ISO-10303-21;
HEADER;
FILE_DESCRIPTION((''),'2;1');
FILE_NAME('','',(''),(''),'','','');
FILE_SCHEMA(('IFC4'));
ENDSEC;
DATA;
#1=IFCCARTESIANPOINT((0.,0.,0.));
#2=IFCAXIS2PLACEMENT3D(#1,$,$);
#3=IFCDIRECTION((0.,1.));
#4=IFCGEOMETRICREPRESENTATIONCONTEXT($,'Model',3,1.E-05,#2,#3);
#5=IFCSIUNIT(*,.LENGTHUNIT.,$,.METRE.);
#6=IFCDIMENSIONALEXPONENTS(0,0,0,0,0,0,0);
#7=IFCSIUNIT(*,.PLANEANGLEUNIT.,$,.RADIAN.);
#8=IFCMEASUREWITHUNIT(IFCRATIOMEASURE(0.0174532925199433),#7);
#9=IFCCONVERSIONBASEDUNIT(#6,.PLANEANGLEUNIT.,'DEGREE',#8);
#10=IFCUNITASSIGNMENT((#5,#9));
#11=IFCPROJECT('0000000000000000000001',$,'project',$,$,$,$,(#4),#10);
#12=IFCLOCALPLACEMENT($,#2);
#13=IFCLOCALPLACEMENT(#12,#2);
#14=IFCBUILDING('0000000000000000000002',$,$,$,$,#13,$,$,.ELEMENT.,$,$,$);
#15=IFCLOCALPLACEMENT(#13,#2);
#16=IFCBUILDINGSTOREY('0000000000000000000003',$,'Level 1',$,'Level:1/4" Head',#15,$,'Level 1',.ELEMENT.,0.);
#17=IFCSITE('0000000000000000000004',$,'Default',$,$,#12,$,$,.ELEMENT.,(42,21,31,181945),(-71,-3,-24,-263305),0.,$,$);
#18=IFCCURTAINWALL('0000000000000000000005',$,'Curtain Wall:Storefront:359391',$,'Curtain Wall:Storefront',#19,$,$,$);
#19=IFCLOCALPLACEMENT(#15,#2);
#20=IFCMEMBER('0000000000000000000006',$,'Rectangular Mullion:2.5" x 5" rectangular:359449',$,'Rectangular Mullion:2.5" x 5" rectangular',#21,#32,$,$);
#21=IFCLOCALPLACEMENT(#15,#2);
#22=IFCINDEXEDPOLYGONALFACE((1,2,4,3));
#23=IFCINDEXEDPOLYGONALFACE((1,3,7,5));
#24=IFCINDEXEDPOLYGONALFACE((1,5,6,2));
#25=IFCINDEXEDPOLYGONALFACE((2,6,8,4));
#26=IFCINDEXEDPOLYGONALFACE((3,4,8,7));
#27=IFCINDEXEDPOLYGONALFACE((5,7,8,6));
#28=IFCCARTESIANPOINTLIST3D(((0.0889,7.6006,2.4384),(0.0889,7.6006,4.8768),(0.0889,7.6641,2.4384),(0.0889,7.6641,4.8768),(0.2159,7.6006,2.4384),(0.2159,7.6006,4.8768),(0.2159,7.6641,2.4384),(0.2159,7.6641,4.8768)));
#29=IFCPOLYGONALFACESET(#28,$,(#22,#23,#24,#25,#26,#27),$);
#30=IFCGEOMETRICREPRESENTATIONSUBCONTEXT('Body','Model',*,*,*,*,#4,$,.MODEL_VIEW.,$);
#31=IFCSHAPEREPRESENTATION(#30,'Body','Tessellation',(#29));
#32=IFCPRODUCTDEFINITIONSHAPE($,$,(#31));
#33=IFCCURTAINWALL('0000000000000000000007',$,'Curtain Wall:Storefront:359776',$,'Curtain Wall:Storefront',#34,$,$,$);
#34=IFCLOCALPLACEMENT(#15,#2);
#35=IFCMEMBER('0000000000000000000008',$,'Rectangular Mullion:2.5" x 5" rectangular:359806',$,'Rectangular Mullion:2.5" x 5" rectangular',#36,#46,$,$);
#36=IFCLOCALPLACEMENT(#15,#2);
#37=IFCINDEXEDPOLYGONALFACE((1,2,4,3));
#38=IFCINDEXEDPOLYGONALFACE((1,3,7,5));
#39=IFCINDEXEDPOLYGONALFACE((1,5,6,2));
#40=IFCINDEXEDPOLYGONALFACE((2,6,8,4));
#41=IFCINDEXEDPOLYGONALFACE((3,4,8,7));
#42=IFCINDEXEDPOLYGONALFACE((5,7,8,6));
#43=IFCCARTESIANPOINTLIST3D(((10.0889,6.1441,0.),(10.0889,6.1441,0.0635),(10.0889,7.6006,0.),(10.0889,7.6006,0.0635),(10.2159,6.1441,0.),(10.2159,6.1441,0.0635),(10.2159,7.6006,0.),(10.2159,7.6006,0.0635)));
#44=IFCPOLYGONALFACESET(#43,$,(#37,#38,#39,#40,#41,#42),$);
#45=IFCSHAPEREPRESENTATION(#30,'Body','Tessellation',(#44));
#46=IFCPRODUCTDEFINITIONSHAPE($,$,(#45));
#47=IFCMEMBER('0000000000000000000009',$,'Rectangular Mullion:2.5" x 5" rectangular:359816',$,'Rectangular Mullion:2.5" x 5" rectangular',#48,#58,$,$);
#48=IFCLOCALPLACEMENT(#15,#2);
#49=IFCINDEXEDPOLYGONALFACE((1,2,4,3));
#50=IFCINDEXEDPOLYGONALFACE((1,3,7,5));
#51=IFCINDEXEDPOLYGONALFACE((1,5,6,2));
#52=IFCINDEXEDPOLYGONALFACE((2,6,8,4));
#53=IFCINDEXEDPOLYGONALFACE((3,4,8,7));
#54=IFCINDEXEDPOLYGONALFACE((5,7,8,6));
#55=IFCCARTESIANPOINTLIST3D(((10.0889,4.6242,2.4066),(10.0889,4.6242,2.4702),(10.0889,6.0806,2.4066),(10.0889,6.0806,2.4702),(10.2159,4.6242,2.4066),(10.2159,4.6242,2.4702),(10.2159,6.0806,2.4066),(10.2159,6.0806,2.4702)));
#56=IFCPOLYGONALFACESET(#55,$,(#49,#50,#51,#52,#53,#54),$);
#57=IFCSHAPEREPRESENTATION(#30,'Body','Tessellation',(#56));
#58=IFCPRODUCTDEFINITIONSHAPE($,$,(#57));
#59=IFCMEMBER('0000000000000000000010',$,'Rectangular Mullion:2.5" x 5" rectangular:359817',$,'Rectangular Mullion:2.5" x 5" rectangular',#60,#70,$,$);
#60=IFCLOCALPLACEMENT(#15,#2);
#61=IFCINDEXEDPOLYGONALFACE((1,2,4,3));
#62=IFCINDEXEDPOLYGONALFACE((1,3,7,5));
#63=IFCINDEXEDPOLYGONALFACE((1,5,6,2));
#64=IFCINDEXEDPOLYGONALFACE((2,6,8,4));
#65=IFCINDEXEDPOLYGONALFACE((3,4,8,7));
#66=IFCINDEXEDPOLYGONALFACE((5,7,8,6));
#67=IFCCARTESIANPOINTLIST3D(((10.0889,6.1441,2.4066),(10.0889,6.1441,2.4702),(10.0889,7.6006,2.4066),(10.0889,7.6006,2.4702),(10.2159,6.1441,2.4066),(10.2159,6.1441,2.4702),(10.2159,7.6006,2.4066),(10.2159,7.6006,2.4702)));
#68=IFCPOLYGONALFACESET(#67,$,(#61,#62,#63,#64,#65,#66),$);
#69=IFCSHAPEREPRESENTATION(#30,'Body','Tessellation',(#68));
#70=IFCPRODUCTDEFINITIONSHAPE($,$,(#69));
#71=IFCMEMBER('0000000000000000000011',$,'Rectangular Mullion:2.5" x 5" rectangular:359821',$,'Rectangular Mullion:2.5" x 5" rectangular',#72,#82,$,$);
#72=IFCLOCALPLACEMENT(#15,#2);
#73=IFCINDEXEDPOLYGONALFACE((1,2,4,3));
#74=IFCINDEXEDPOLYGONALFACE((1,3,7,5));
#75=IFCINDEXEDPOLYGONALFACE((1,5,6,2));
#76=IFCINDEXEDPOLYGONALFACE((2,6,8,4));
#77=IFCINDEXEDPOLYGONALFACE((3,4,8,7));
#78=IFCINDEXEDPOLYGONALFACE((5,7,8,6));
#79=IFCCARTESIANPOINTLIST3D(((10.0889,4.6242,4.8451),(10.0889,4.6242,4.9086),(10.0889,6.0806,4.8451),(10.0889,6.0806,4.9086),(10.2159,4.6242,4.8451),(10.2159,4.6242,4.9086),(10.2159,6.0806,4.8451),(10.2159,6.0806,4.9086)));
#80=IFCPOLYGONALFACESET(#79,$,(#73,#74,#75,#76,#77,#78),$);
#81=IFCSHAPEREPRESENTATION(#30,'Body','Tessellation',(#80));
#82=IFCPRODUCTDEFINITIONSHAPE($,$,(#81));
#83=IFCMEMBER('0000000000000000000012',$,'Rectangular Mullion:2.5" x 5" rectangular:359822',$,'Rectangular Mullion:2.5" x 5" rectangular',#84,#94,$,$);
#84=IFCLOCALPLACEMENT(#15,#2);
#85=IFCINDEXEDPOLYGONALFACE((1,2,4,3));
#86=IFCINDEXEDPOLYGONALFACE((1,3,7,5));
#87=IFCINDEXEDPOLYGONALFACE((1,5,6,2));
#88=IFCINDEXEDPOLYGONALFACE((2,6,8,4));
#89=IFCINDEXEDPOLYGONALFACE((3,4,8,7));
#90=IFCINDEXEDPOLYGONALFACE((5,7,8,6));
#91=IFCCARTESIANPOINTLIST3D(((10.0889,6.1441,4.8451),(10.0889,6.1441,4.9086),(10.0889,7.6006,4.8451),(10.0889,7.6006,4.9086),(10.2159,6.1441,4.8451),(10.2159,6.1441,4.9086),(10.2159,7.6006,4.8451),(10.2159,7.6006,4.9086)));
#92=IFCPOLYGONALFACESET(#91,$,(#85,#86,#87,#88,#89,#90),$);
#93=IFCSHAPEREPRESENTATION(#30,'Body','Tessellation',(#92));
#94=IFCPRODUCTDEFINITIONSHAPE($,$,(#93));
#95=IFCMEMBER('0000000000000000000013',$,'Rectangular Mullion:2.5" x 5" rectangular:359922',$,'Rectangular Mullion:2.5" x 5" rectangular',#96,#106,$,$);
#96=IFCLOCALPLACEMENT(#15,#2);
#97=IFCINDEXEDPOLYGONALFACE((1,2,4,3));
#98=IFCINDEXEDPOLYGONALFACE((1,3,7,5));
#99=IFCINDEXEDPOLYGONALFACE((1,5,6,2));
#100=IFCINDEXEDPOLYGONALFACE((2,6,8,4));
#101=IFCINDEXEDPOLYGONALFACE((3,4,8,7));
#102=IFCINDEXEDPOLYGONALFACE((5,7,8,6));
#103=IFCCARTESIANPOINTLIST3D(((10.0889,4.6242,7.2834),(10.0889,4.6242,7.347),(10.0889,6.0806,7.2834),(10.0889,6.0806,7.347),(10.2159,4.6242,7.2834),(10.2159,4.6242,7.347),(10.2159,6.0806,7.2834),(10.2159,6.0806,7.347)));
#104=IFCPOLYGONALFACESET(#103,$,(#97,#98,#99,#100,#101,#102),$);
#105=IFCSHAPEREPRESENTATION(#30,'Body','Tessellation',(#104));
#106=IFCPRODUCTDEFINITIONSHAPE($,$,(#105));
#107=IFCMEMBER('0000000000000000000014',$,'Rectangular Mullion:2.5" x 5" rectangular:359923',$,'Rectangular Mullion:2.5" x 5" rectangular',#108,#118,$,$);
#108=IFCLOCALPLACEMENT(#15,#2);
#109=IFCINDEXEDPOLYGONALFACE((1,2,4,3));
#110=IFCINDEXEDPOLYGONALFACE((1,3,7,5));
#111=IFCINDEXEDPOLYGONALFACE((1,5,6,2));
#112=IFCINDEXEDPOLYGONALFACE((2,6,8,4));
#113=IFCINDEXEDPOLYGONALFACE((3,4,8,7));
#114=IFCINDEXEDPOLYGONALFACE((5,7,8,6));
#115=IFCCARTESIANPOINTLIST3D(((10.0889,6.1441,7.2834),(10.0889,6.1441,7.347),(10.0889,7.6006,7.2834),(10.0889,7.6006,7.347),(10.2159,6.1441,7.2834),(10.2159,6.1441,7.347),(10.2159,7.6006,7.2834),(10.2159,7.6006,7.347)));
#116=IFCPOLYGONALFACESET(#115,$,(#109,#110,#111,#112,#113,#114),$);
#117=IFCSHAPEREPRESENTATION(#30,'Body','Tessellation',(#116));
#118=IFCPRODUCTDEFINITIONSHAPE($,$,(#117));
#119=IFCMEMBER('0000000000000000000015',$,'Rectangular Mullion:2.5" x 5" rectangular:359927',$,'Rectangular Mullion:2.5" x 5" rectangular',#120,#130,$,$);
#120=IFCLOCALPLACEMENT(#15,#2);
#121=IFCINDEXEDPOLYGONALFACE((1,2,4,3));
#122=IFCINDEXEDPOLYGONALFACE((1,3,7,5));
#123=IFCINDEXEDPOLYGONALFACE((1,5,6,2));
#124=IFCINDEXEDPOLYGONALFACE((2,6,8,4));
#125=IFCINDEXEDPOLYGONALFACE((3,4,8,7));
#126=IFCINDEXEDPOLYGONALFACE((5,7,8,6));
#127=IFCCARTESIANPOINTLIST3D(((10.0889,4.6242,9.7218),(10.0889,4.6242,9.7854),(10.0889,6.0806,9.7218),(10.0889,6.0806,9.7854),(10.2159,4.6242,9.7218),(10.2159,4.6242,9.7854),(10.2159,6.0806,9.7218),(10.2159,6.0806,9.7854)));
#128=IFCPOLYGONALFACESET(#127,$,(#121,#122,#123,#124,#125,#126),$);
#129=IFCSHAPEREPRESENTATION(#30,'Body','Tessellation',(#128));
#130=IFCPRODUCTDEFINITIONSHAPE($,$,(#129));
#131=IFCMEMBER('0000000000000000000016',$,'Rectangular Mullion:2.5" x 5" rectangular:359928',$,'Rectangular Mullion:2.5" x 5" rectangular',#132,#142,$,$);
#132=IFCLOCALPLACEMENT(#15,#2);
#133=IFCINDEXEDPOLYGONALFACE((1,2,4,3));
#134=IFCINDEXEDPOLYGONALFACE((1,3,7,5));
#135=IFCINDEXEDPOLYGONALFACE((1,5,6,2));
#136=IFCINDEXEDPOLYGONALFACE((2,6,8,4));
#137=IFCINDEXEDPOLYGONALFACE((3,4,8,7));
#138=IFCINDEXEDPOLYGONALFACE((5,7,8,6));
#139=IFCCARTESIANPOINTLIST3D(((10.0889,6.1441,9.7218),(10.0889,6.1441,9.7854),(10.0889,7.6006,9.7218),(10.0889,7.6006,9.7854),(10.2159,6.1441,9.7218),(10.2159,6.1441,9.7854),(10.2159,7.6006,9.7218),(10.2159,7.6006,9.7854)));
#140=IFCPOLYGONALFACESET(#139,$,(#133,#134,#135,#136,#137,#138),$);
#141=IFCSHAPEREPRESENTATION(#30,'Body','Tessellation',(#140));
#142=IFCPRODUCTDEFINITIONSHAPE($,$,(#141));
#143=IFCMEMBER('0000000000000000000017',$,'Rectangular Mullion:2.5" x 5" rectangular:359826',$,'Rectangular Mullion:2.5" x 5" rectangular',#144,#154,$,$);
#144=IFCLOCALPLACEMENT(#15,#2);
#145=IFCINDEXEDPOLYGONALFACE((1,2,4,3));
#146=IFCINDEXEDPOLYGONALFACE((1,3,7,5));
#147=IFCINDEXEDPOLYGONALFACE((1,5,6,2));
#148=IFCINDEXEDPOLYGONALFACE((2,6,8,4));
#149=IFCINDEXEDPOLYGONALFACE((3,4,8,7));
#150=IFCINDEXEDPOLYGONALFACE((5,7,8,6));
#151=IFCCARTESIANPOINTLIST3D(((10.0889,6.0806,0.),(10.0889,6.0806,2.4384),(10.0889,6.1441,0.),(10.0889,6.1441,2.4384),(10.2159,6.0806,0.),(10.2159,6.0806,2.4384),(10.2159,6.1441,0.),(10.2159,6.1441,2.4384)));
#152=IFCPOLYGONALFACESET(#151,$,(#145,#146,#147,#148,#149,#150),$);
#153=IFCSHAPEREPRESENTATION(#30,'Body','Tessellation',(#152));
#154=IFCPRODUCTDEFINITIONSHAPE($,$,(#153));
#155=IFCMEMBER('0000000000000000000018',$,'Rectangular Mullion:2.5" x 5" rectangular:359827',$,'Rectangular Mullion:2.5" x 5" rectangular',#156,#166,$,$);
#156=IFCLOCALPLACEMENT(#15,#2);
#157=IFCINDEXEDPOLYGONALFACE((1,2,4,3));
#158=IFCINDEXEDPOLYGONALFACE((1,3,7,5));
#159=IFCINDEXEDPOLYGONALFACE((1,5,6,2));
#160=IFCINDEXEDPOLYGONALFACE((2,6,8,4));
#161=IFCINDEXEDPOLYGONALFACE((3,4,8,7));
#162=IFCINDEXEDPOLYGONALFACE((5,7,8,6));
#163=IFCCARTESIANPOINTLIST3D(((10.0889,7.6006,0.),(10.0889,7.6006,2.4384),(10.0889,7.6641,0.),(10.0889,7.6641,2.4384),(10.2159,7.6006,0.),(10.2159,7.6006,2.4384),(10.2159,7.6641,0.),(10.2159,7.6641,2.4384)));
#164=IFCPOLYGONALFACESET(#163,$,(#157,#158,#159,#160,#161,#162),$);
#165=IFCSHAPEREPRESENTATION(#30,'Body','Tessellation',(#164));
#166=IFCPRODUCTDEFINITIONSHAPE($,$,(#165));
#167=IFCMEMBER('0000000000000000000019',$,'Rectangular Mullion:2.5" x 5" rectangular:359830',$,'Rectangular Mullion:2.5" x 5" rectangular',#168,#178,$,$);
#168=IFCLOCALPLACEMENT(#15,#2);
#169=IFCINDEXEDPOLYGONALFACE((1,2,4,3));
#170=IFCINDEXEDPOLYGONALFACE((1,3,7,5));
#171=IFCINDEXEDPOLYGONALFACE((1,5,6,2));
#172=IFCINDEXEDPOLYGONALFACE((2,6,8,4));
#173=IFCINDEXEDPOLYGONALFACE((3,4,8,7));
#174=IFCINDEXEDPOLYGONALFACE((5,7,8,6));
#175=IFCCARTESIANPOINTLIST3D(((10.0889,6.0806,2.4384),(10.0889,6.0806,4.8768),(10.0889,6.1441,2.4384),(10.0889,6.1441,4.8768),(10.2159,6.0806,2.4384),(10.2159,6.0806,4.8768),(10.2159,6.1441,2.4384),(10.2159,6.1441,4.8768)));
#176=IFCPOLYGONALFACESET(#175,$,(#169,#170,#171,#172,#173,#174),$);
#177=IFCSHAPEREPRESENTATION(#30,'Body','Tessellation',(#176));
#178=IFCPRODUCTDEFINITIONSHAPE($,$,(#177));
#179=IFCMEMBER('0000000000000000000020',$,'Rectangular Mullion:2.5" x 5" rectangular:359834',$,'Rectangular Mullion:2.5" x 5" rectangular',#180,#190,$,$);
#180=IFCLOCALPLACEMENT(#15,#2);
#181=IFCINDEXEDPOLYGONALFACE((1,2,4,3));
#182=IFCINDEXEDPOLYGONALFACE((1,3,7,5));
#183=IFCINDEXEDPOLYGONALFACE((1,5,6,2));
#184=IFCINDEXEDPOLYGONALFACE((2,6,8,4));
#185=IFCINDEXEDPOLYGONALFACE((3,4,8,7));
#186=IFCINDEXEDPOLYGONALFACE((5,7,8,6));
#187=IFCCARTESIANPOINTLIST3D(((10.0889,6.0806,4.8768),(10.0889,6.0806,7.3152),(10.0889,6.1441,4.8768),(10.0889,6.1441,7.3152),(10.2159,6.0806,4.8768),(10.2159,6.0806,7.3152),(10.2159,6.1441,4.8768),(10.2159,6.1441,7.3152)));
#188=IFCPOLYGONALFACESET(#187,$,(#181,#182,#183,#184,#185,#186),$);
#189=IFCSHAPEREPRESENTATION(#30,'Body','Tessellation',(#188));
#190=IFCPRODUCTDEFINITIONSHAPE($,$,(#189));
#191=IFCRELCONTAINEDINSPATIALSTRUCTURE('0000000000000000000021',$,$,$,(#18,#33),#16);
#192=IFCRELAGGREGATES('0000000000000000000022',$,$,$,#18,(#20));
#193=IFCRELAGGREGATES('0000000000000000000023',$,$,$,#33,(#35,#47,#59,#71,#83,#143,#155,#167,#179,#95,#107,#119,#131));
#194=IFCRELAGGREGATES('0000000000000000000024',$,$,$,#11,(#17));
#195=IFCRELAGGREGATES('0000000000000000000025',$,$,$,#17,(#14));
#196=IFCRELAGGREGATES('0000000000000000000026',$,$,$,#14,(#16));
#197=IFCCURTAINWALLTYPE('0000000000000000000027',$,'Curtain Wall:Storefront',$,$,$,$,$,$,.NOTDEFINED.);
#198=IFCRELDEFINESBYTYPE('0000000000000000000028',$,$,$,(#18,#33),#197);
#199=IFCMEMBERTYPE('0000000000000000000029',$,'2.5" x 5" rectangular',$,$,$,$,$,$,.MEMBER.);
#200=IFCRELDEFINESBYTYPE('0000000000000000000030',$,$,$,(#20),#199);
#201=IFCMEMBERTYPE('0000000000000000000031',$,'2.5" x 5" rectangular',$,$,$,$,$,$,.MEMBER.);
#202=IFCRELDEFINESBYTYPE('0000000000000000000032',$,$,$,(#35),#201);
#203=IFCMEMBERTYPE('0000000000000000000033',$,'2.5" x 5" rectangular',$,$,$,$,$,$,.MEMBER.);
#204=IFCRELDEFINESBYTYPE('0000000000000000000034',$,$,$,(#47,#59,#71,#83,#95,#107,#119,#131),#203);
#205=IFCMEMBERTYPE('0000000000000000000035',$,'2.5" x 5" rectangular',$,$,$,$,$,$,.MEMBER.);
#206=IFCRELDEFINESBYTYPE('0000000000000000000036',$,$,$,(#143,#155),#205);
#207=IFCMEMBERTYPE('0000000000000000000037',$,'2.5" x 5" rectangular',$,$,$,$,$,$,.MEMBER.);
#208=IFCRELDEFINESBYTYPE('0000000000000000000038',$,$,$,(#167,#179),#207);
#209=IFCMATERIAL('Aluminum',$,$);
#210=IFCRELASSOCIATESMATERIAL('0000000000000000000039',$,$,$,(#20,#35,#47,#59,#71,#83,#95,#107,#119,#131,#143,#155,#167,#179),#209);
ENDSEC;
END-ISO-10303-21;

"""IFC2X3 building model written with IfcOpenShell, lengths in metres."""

from ifc_helpers import new_model, entity, si_unit, converted_unit, direction, frame, origin, origin_2d_with_axis, place, context, subcontext, project, spatial, rectangle, extrude, source, transform, mapped, material, type_object, type_shapes, element, aggregate, save


model = new_model("IFC2X3")

# Units and contexts
model_context = context("Model", 3, precision=1e-05, world=origin(), true_north=direction((0.0, 1.0)))
body_context = subcontext(model_context, "Body", "Model", "MODEL_VIEW")
ifc_project = project(units=[si_unit("LENGTHUNIT", "METRE"), converted_unit("PLANEANGLEUNIT", "DEGREE", entity("IfcRatioMeasure", 0.0174532925199433), si_unit("PLANEANGLEUNIT", "RADIAN"), dimensions=[0, 0, 0, 0, 0, 0, 0])], contexts=[model_context])

# Site, building, storey
site_placement = place(None, origin())
site = spatial("IfcSite", under=ifc_project, at=site_placement, Name="Default", CompositionType="ELEMENT", RefLatitude=(42, 21, 31, 181945), RefLongitude=(-71, -3, -24, -263305), RefElevation=0.0)
building_placement = place(site_placement, origin())
building = spatial("IfcBuilding", under=site, at=building_placement, CompositionType="ELEMENT")
storey_placement = place(building_placement, origin())
storey = spatial("IfcBuildingStorey", under=building, at=storey_placement, Name="Level 1", ObjectType="Level:1/4\" Head", LongName="Level 1", CompositionType="ELEMENT", Elevation=0.0)

# Curtain wall, member
curtain_wall_type = type_object("IfcCurtainWallType", Name="Curtain Wall:Storefront", PredefinedType="NOTDEFINED")
curtain_wall_1_placement = place(storey_placement, origin())
curtain_wall_1 = element("IfcCurtainWall", 1, at=curtain_wall_1_placement, inside=storey, type_object=curtain_wall_type, Name="Curtain Wall:Storefront:359391", ObjectType="Curtain Wall:Storefront")
ifc_material_1 = material(Name="Aluminum")
member_type_1 = type_object("IfcMemberType", Name="2.5\" x 5\" rectangular", PredefinedType="MEMBER")
shared_shape_1 = source(origin(), body_context, "Body", "SweptSolid", [
    extrude(rectangle(XDim=0.127, YDim=0.0635, at=origin_2d_with_axis()), frame((0.0, 0.0, -2.4384), z_axis=(0.0, 0.0, 1.0), x_axis=(0.0, -1.0, 0.0)), (0.0, 0.0, 1.0), 2.4384),
])
type_shapes(member_type_1, [shared_shape_1])
member_1_placement = place(storey_placement, frame((0.1524, 7.6324, 2.4384), z_axis=(0.0, 0.0, -1.0), x_axis=(0.0, 1.0, 0.0)))
member_1 = element("IfcMember", 2, at=member_1_placement, type_object=member_type_1, material=ifc_material_1, Name="Rectangular Mullion:2.5\" x 5\" rectangular:359449", ObjectType="Rectangular Mullion:2.5\" x 5\" rectangular", context=body_context, shape_type="MappedRepresentation", body=[
    mapped(shared_shape_1, transform((0.0, 0.0, 0.0), scale=1.0)),
])
aggregate(curtain_wall_1, [member_1])

# Curtain wall, members
curtain_wall_2_placement = place(storey_placement, origin())
curtain_wall_2 = element("IfcCurtainWall", 3, at=curtain_wall_2_placement, inside=storey, type_object=curtain_wall_type, Name="Curtain Wall:Storefront:359776", ObjectType="Curtain Wall:Storefront")
member_type_2 = type_object("IfcMemberType", Name="2.5\" x 5\" rectangular", PredefinedType="MEMBER")
shared_shape_2 = source(origin(), body_context, "Body", "SweptSolid", [
    extrude(rectangle(XDim=0.127, YDim=0.0635, at=origin_2d_with_axis()), frame((-0.0318, 0.0, -1.4565), z_axis=(0.0, 0.0, 1.0), x_axis=(0.0, -1.0, 0.0)), (0.0, 0.0, 1.0), 1.4565),
])
type_shapes(member_type_2, [shared_shape_2])
member_2_placement = place(storey_placement, frame((10.1524, 6.1441, 0.0), z_axis=(0.0, -1.0, 0.0), x_axis=(0.0, 0.0, -1.0)))
member_2 = element("IfcMember", 4, at=member_2_placement, type_object=member_type_2, material=ifc_material_1, Name="Rectangular Mullion:2.5\" x 5\" rectangular:359806", ObjectType="Rectangular Mullion:2.5\" x 5\" rectangular", context=body_context, shape_type="MappedRepresentation", body=[
    mapped(shared_shape_2, transform((0.0, 0.0, 0.0), scale=1.0)),
])
member_type_3 = type_object("IfcMemberType", Name="2.5\" x 5\" rectangular", PredefinedType="MEMBER")
shared_shape_3 = source(origin(), body_context, "Body", "SweptSolid", [
    extrude(rectangle(XDim=0.127, YDim=0.0635, at=origin_2d_with_axis()), frame((0.0, 0.0, -1.4565), z_axis=(0.0, 0.0, 1.0), x_axis=(0.0, -1.0, 0.0)), (0.0, 0.0, 1.0), 1.4565),
])
type_shapes(member_type_3, [shared_shape_3])
member_3_placement = place(storey_placement, frame((10.1524, 6.0806, 2.4384), z_axis=(0.0, 1.0, 0.0), x_axis=(0.0, 0.0, 1.0)))
member_3 = element("IfcMember", 5, at=member_3_placement, type_object=member_type_3, material=ifc_material_1, Name="Rectangular Mullion:2.5\" x 5\" rectangular:359816", ObjectType="Rectangular Mullion:2.5\" x 5\" rectangular", context=body_context, shape_type="MappedRepresentation", body=[
    mapped(shared_shape_3, transform((0.0, 0.0, 0.0), scale=1.0)),
])
member_4_placement = place(storey_placement, frame((10.1524, 7.6006, 2.4384), z_axis=(0.0, 1.0, 0.0), x_axis=(0.0, 0.0, 1.0)))
member_4 = element("IfcMember", 6, at=member_4_placement, type_object=member_type_3, material=ifc_material_1, Name="Rectangular Mullion:2.5\" x 5\" rectangular:359817", ObjectType="Rectangular Mullion:2.5\" x 5\" rectangular", context=body_context, shape_type="MappedRepresentation", body=[
    mapped(shared_shape_3, transform((0.0, 0.0, 0.0), scale=1.0)),
])
member_5_placement = place(storey_placement, frame((10.1524, 6.0806, 4.8768), z_axis=(0.0, 1.0, 0.0), x_axis=(0.0, 0.0, 1.0)))
member_5 = element("IfcMember", 7, at=member_5_placement, type_object=member_type_3, material=ifc_material_1, Name="Rectangular Mullion:2.5\" x 5\" rectangular:359821", ObjectType="Rectangular Mullion:2.5\" x 5\" rectangular", context=body_context, shape_type="MappedRepresentation", body=[
    mapped(shared_shape_3, transform((0.0, 0.0, 0.0), scale=1.0)),
])
member_6_placement = place(storey_placement, frame((10.1524, 7.6006, 4.8768), z_axis=(0.0, 1.0, 0.0), x_axis=(0.0, 0.0, 1.0)))
member_6 = element("IfcMember", 8, at=member_6_placement, type_object=member_type_3, material=ifc_material_1, Name="Rectangular Mullion:2.5\" x 5\" rectangular:359822", ObjectType="Rectangular Mullion:2.5\" x 5\" rectangular", context=body_context, shape_type="MappedRepresentation", body=[
    mapped(shared_shape_3, transform((0.0, 0.0, 0.0), scale=1.0)),
])
member_7_placement = place(storey_placement, frame((10.1524, 6.0806, 7.3152), z_axis=(0.0, 1.0, 0.0), x_axis=(0.0, 0.0, 1.0)))
member_7 = element("IfcMember", 9, at=member_7_placement, type_object=member_type_3, material=ifc_material_1, Name="Rectangular Mullion:2.5\" x 5\" rectangular:359922", ObjectType="Rectangular Mullion:2.5\" x 5\" rectangular", context=body_context, shape_type="MappedRepresentation", body=[
    mapped(shared_shape_3, transform((0.0, 0.0, 0.0), scale=1.0)),
])
member_8_placement = place(storey_placement, frame((10.1524, 7.6006, 7.3152), z_axis=(0.0, 1.0, 0.0), x_axis=(0.0, 0.0, 1.0)))
member_8 = element("IfcMember", 10, at=member_8_placement, type_object=member_type_3, material=ifc_material_1, Name="Rectangular Mullion:2.5\" x 5\" rectangular:359923", ObjectType="Rectangular Mullion:2.5\" x 5\" rectangular", context=body_context, shape_type="MappedRepresentation", body=[
    mapped(shared_shape_3, transform((0.0, 0.0, 0.0), scale=1.0)),
])
member_9_placement = place(storey_placement, frame((10.1524, 6.0806, 9.7536), z_axis=(0.0, 1.0, 0.0), x_axis=(0.0, 0.0, 1.0)))
member_9 = element("IfcMember", 11, at=member_9_placement, type_object=member_type_3, material=ifc_material_1, Name="Rectangular Mullion:2.5\" x 5\" rectangular:359927", ObjectType="Rectangular Mullion:2.5\" x 5\" rectangular", context=body_context, shape_type="MappedRepresentation", body=[
    mapped(shared_shape_3, transform((0.0, 0.0, 0.0), scale=1.0)),
])
member_10_placement = place(storey_placement, frame((10.1524, 7.6006, 9.7536), z_axis=(0.0, 1.0, 0.0), x_axis=(0.0, 0.0, 1.0)))
member_10 = element("IfcMember", 12, at=member_10_placement, type_object=member_type_3, material=ifc_material_1, Name="Rectangular Mullion:2.5\" x 5\" rectangular:359928", ObjectType="Rectangular Mullion:2.5\" x 5\" rectangular", context=body_context, shape_type="MappedRepresentation", body=[
    mapped(shared_shape_3, transform((0.0, 0.0, 0.0), scale=1.0)),
])
member_type_4 = type_object("IfcMemberType", Name="2.5\" x 5\" rectangular", PredefinedType="MEMBER")
shared_shape_4 = source(origin(), body_context, "Body", "SweptSolid", [
    extrude(rectangle(XDim=0.127, YDim=0.0635, at=origin_2d_with_axis()), frame((0.0, 0.0, -2.4384), z_axis=(0.0, 0.0, 1.0), x_axis=(0.0, -1.0, 0.0)), (0.0, 0.0, 1.0), 2.4384),
])
type_shapes(member_type_4, [shared_shape_4])
member_11_placement = place(storey_placement, frame((10.1524, 6.1124, 0.0), z_axis=(0.0, 0.0, -1.0), x_axis=(0.0, 1.0, 0.0)))
member_11 = element("IfcMember", 13, at=member_11_placement, type_object=member_type_4, material=ifc_material_1, Name="Rectangular Mullion:2.5\" x 5\" rectangular:359826", ObjectType="Rectangular Mullion:2.5\" x 5\" rectangular", context=body_context, shape_type="MappedRepresentation", body=[
    mapped(shared_shape_4, transform((0.0, 0.0, 0.0), scale=1.0)),
])
member_12_placement = place(storey_placement, frame((10.1524, 7.6324, 0.0), z_axis=(0.0, 0.0, -1.0), x_axis=(0.0, 1.0, 0.0)))
member_12 = element("IfcMember", 14, at=member_12_placement, type_object=member_type_4, material=ifc_material_1, Name="Rectangular Mullion:2.5\" x 5\" rectangular:359827", ObjectType="Rectangular Mullion:2.5\" x 5\" rectangular", context=body_context, shape_type="MappedRepresentation", body=[
    mapped(shared_shape_4, transform((0.0, 0.0, 0.0), scale=1.0)),
])
member_type_5 = type_object("IfcMemberType", Name="2.5\" x 5\" rectangular", PredefinedType="MEMBER")
shared_shape_5 = source(origin(), body_context, "Body", "SweptSolid", [
    extrude(rectangle(XDim=0.127, YDim=0.0635, at=origin_2d_with_axis()), frame((0.0, 0.0, -2.4384), z_axis=(0.0, 0.0, 1.0), x_axis=(0.0, -1.0, 0.0)), (0.0, 0.0, 1.0), 2.4384),
])
type_shapes(member_type_5, [shared_shape_5])
member_13_placement = place(storey_placement, frame((10.1524, 6.1124, 2.4384), z_axis=(0.0, 0.0, -1.0), x_axis=(0.0, 1.0, 0.0)))
member_13 = element("IfcMember", 15, at=member_13_placement, type_object=member_type_5, material=ifc_material_1, Name="Rectangular Mullion:2.5\" x 5\" rectangular:359830", ObjectType="Rectangular Mullion:2.5\" x 5\" rectangular", context=body_context, shape_type="MappedRepresentation", body=[
    mapped(shared_shape_5, transform((0.0, 0.0, 0.0), scale=1.0)),
])
member_14_placement = place(storey_placement, frame((10.1524, 6.1124, 4.8768), z_axis=(0.0, 0.0, -1.0), x_axis=(0.0, 1.0, 0.0)))
member_14 = element("IfcMember", 16, at=member_14_placement, type_object=member_type_5, material=ifc_material_1, Name="Rectangular Mullion:2.5\" x 5\" rectangular:359834", ObjectType="Rectangular Mullion:2.5\" x 5\" rectangular", context=body_context, shape_type="MappedRepresentation", body=[
    mapped(shared_shape_5, transform((0.0, 0.0, 0.0), scale=1.0)),
])
aggregate(curtain_wall_2, [member_2, member_3, member_4, member_5, member_6, member_11, member_12, member_13, member_14, member_7, member_8, member_9, member_10])

save(model, "model.ifc")
